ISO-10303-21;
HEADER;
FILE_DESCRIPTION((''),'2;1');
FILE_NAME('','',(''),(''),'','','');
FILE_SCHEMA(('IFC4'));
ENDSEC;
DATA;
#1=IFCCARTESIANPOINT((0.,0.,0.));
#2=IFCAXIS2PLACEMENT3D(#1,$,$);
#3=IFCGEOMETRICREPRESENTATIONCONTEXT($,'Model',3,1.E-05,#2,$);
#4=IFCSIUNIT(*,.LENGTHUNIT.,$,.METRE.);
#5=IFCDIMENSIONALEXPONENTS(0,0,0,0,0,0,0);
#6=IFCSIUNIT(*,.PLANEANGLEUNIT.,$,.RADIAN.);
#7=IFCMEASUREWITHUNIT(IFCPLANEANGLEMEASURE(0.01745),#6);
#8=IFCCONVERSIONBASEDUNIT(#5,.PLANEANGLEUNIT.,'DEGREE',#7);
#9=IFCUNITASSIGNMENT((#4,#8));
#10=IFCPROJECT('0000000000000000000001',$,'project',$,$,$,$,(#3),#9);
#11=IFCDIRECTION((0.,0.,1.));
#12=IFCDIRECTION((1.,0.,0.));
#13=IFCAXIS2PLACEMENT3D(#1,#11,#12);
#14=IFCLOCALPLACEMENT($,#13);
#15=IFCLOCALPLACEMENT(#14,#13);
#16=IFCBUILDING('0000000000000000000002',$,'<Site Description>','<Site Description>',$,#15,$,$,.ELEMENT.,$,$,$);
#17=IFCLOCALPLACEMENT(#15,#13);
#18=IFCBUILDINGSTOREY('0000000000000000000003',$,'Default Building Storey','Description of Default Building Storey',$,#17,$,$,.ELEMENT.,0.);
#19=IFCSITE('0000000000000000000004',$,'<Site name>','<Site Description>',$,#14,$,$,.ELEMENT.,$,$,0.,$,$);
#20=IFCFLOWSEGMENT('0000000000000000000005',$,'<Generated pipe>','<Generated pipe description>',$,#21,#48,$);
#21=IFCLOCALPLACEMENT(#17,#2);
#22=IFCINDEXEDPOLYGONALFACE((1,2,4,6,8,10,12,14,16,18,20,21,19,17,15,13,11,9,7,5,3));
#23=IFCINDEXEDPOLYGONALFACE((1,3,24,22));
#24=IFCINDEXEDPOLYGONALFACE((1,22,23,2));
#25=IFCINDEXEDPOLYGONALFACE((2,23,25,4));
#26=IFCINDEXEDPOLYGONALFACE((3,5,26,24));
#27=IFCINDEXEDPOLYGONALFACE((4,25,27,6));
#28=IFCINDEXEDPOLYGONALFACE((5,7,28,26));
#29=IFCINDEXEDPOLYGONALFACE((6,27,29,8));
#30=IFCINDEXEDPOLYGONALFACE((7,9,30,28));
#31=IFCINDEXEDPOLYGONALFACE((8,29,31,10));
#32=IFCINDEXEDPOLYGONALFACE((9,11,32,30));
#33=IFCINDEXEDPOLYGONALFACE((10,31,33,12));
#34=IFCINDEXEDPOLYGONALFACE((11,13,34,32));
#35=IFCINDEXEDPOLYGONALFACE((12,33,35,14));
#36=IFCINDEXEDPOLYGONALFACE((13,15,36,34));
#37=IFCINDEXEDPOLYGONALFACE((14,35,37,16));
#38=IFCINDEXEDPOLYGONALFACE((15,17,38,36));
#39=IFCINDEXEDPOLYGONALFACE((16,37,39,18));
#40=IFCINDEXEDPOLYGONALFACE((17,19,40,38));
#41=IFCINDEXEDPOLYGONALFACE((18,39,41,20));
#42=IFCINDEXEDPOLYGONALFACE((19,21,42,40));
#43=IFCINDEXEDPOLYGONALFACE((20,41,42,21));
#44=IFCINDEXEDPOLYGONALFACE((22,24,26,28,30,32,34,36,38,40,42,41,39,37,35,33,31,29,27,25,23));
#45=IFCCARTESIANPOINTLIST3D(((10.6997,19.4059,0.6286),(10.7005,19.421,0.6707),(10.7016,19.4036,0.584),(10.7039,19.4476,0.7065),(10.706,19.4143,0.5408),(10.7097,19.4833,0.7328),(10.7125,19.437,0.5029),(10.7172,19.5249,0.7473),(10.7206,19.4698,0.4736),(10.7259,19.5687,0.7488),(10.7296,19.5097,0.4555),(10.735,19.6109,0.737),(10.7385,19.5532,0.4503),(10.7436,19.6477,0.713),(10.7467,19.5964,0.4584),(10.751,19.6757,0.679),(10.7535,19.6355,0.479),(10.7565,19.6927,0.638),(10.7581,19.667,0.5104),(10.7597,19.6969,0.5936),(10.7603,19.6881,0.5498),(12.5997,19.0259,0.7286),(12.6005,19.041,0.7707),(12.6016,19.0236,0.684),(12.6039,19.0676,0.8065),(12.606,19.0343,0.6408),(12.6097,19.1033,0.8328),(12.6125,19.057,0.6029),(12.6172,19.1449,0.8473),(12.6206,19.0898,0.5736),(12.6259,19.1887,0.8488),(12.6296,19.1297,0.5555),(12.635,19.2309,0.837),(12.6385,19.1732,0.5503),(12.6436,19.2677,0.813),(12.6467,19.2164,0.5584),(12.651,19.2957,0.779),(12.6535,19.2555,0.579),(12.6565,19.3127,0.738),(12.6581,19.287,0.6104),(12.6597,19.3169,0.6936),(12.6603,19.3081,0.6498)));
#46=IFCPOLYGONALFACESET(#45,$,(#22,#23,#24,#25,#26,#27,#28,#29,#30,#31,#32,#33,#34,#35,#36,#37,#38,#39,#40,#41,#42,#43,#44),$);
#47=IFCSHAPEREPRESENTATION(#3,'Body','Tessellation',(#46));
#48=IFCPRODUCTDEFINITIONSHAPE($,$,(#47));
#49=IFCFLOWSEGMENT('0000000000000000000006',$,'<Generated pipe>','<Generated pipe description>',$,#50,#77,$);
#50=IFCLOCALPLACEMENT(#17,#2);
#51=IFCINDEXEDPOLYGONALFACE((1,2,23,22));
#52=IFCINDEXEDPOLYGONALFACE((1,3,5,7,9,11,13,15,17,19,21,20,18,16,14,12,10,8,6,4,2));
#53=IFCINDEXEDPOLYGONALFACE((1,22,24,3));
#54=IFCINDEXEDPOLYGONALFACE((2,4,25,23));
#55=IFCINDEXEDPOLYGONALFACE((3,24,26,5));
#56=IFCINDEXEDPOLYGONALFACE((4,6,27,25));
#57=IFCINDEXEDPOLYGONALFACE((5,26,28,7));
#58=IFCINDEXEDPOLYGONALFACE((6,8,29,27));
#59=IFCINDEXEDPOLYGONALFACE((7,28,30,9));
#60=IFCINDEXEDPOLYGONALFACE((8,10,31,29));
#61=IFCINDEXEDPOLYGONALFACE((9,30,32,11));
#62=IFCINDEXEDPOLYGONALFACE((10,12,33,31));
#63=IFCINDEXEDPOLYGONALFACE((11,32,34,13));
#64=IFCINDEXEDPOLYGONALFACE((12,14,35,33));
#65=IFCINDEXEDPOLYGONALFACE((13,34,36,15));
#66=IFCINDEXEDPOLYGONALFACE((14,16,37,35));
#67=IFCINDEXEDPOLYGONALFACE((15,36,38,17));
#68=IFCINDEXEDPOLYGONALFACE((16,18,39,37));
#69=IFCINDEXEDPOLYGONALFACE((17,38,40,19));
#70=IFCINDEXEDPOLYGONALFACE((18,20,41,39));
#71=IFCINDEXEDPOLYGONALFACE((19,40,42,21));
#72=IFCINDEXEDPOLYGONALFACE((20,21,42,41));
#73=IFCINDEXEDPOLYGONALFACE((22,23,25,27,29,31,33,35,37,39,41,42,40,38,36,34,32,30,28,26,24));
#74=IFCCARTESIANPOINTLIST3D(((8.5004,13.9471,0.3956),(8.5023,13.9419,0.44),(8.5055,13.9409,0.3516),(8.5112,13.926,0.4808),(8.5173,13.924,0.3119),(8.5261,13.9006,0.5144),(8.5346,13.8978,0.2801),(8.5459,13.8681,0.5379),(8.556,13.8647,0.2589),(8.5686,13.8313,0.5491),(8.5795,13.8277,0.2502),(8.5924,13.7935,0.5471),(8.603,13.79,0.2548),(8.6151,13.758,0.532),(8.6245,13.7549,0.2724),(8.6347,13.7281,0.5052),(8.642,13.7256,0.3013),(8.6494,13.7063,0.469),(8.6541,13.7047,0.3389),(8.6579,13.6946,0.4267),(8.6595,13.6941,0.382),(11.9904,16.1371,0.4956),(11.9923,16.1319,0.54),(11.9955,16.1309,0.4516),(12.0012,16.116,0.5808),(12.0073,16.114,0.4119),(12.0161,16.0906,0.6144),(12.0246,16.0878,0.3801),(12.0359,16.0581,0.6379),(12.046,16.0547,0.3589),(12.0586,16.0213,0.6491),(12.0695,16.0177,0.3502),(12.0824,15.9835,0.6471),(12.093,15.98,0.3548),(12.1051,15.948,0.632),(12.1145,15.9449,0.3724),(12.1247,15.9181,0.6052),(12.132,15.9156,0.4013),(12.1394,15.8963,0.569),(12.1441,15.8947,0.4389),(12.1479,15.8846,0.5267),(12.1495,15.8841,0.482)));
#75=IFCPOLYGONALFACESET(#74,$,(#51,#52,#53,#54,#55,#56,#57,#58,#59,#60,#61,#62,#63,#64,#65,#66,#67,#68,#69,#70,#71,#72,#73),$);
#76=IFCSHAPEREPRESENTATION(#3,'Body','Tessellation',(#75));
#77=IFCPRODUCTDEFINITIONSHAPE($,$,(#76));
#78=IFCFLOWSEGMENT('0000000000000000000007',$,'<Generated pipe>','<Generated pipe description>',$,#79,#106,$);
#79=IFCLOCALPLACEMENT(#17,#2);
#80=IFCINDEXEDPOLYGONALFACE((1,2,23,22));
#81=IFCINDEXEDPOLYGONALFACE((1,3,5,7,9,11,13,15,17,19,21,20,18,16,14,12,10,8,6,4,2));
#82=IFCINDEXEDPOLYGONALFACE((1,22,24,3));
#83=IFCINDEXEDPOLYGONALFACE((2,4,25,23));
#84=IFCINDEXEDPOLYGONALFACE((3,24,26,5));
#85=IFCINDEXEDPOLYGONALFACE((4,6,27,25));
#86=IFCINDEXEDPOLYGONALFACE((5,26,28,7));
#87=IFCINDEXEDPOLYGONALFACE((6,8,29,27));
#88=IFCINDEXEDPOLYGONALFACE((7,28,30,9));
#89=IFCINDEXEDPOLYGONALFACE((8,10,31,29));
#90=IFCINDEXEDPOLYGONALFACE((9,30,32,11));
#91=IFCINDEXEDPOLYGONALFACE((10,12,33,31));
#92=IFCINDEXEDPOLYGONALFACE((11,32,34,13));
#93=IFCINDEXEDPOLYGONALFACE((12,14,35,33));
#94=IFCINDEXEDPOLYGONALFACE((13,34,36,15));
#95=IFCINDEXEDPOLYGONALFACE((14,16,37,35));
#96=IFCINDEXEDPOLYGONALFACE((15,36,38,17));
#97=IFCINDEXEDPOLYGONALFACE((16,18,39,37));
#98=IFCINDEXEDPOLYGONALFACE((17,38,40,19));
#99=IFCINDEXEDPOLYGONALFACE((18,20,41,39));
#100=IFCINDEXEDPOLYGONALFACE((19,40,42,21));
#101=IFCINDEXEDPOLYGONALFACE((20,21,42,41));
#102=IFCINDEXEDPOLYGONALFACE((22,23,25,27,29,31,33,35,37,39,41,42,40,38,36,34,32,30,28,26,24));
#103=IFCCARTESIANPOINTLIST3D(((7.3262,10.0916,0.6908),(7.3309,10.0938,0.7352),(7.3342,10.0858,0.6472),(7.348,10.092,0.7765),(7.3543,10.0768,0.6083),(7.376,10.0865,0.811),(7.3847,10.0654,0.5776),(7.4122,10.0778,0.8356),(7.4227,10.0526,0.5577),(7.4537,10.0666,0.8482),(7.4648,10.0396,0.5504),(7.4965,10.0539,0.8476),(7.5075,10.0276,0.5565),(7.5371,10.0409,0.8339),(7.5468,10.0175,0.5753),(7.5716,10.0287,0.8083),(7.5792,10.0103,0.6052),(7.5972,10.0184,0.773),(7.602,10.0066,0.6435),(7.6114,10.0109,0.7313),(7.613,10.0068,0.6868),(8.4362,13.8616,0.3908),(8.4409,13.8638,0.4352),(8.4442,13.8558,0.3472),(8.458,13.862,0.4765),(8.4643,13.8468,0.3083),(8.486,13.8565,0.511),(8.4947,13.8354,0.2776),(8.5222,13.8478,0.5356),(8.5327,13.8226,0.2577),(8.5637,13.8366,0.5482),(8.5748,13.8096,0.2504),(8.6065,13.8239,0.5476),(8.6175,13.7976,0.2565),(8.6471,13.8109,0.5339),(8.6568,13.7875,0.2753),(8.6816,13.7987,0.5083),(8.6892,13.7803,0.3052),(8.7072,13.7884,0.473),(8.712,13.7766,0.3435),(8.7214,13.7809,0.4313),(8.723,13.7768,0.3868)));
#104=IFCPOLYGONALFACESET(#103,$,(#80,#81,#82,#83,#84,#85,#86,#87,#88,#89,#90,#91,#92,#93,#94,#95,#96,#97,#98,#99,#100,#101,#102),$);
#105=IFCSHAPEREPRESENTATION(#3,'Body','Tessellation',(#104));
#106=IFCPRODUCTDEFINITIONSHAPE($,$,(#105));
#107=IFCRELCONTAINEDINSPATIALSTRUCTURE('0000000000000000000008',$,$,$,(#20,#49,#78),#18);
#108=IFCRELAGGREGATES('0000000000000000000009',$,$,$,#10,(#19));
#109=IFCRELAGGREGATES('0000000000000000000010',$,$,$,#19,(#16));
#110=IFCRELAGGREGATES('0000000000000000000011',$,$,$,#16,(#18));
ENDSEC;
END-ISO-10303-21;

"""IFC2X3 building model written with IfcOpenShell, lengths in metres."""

from ifc_helpers import new_model, entity, si_unit, converted_unit, frame, origin, origin_with_axes, origin_2d_with_axis, place, context, project, spatial, circle, extrude, element, save


model = new_model("IFC2X3")

# Units and contexts
model_context = context("Model", 3, precision=1e-05, world=origin())
ifc_project = project(units=[si_unit("LENGTHUNIT", "METRE"), converted_unit("PLANEANGLEUNIT", "DEGREE", entity("IfcPlaneAngleMeasure", 0.01745), si_unit("PLANEANGLEUNIT", "RADIAN"), dimensions=[0, 0, 0, 0, 0, 0, 0])], contexts=[model_context])

# Site, building, storey
site_placement = place(None, origin_with_axes())
site = spatial("IfcSite", under=ifc_project, at=site_placement, Name="<Site name>", Description="<Site Description>", CompositionType="ELEMENT", RefElevation=0.0)
building_placement = place(site_placement, origin_with_axes())
building = spatial("IfcBuilding", under=site, at=building_placement, Name="<Site Description>", Description="<Site Description>", CompositionType="ELEMENT")
storey_placement = place(building_placement, origin_with_axes())
storey = spatial("IfcBuildingStorey", under=building, at=storey_placement, Name="Default Building Storey", Description="Description of Default Building Storey", CompositionType="ELEMENT", Elevation=0.0)

# Flow segments
flow_segment_1_placement = place(storey_placement, frame((10.73, 19.55, 0.6), z_axis=(0.979277, -0.195855, 0.051541), x_axis=(0.033132, 0.405994, 0.913275)))
element("IfcFlowSegment", 1, at=flow_segment_1_placement, inside=storey, Name="<Generated pipe>", Description="<Generated pipe description>", context=model_context, shape_type="SweptSolid", body=[
    extrude(circle(Radius=0.15, at=origin_2d_with_axis()), origin_with_axes(), (0.0, 0.0, 1.0), 1.9402),
])
flow_segment_2_placement = place(storey_placement, frame((12.07, 16.01, 0.5), z_axis=(-0.846793, -0.531369, -0.024263), x_axis=(-0.458866, 0.706659, 0.538587)))
element("IfcFlowSegment", 2, at=flow_segment_2_placement, inside=storey, Name="<Generated pipe>", Description="<Generated pipe description>", context=model_context, shape_type="SweptSolid", body=[
    extrude(circle(Radius=0.15, at=origin_2d_with_axis()), origin_with_axes(), (0.0, 0.0, 1.0), 4.1214),
])
flow_segment_3_placement = place(storey_placement, frame((8.58, 13.82, 0.4), z_axis=(-0.281623, -0.956502, 0.076114), x_axis=(0.176993, 0.02618, 0.983864)))
element("IfcFlowSegment", 3, at=flow_segment_3_placement, inside=storey, Name="<Generated pipe>", Description="<Generated pipe description>", context=model_context, shape_type="SweptSolid", body=[
    extrude(circle(Radius=0.15, at=origin_2d_with_axis()), origin_with_axes(), (0.0, 0.0, 1.0), 3.9414),
])

save(model, "model.ifc")
